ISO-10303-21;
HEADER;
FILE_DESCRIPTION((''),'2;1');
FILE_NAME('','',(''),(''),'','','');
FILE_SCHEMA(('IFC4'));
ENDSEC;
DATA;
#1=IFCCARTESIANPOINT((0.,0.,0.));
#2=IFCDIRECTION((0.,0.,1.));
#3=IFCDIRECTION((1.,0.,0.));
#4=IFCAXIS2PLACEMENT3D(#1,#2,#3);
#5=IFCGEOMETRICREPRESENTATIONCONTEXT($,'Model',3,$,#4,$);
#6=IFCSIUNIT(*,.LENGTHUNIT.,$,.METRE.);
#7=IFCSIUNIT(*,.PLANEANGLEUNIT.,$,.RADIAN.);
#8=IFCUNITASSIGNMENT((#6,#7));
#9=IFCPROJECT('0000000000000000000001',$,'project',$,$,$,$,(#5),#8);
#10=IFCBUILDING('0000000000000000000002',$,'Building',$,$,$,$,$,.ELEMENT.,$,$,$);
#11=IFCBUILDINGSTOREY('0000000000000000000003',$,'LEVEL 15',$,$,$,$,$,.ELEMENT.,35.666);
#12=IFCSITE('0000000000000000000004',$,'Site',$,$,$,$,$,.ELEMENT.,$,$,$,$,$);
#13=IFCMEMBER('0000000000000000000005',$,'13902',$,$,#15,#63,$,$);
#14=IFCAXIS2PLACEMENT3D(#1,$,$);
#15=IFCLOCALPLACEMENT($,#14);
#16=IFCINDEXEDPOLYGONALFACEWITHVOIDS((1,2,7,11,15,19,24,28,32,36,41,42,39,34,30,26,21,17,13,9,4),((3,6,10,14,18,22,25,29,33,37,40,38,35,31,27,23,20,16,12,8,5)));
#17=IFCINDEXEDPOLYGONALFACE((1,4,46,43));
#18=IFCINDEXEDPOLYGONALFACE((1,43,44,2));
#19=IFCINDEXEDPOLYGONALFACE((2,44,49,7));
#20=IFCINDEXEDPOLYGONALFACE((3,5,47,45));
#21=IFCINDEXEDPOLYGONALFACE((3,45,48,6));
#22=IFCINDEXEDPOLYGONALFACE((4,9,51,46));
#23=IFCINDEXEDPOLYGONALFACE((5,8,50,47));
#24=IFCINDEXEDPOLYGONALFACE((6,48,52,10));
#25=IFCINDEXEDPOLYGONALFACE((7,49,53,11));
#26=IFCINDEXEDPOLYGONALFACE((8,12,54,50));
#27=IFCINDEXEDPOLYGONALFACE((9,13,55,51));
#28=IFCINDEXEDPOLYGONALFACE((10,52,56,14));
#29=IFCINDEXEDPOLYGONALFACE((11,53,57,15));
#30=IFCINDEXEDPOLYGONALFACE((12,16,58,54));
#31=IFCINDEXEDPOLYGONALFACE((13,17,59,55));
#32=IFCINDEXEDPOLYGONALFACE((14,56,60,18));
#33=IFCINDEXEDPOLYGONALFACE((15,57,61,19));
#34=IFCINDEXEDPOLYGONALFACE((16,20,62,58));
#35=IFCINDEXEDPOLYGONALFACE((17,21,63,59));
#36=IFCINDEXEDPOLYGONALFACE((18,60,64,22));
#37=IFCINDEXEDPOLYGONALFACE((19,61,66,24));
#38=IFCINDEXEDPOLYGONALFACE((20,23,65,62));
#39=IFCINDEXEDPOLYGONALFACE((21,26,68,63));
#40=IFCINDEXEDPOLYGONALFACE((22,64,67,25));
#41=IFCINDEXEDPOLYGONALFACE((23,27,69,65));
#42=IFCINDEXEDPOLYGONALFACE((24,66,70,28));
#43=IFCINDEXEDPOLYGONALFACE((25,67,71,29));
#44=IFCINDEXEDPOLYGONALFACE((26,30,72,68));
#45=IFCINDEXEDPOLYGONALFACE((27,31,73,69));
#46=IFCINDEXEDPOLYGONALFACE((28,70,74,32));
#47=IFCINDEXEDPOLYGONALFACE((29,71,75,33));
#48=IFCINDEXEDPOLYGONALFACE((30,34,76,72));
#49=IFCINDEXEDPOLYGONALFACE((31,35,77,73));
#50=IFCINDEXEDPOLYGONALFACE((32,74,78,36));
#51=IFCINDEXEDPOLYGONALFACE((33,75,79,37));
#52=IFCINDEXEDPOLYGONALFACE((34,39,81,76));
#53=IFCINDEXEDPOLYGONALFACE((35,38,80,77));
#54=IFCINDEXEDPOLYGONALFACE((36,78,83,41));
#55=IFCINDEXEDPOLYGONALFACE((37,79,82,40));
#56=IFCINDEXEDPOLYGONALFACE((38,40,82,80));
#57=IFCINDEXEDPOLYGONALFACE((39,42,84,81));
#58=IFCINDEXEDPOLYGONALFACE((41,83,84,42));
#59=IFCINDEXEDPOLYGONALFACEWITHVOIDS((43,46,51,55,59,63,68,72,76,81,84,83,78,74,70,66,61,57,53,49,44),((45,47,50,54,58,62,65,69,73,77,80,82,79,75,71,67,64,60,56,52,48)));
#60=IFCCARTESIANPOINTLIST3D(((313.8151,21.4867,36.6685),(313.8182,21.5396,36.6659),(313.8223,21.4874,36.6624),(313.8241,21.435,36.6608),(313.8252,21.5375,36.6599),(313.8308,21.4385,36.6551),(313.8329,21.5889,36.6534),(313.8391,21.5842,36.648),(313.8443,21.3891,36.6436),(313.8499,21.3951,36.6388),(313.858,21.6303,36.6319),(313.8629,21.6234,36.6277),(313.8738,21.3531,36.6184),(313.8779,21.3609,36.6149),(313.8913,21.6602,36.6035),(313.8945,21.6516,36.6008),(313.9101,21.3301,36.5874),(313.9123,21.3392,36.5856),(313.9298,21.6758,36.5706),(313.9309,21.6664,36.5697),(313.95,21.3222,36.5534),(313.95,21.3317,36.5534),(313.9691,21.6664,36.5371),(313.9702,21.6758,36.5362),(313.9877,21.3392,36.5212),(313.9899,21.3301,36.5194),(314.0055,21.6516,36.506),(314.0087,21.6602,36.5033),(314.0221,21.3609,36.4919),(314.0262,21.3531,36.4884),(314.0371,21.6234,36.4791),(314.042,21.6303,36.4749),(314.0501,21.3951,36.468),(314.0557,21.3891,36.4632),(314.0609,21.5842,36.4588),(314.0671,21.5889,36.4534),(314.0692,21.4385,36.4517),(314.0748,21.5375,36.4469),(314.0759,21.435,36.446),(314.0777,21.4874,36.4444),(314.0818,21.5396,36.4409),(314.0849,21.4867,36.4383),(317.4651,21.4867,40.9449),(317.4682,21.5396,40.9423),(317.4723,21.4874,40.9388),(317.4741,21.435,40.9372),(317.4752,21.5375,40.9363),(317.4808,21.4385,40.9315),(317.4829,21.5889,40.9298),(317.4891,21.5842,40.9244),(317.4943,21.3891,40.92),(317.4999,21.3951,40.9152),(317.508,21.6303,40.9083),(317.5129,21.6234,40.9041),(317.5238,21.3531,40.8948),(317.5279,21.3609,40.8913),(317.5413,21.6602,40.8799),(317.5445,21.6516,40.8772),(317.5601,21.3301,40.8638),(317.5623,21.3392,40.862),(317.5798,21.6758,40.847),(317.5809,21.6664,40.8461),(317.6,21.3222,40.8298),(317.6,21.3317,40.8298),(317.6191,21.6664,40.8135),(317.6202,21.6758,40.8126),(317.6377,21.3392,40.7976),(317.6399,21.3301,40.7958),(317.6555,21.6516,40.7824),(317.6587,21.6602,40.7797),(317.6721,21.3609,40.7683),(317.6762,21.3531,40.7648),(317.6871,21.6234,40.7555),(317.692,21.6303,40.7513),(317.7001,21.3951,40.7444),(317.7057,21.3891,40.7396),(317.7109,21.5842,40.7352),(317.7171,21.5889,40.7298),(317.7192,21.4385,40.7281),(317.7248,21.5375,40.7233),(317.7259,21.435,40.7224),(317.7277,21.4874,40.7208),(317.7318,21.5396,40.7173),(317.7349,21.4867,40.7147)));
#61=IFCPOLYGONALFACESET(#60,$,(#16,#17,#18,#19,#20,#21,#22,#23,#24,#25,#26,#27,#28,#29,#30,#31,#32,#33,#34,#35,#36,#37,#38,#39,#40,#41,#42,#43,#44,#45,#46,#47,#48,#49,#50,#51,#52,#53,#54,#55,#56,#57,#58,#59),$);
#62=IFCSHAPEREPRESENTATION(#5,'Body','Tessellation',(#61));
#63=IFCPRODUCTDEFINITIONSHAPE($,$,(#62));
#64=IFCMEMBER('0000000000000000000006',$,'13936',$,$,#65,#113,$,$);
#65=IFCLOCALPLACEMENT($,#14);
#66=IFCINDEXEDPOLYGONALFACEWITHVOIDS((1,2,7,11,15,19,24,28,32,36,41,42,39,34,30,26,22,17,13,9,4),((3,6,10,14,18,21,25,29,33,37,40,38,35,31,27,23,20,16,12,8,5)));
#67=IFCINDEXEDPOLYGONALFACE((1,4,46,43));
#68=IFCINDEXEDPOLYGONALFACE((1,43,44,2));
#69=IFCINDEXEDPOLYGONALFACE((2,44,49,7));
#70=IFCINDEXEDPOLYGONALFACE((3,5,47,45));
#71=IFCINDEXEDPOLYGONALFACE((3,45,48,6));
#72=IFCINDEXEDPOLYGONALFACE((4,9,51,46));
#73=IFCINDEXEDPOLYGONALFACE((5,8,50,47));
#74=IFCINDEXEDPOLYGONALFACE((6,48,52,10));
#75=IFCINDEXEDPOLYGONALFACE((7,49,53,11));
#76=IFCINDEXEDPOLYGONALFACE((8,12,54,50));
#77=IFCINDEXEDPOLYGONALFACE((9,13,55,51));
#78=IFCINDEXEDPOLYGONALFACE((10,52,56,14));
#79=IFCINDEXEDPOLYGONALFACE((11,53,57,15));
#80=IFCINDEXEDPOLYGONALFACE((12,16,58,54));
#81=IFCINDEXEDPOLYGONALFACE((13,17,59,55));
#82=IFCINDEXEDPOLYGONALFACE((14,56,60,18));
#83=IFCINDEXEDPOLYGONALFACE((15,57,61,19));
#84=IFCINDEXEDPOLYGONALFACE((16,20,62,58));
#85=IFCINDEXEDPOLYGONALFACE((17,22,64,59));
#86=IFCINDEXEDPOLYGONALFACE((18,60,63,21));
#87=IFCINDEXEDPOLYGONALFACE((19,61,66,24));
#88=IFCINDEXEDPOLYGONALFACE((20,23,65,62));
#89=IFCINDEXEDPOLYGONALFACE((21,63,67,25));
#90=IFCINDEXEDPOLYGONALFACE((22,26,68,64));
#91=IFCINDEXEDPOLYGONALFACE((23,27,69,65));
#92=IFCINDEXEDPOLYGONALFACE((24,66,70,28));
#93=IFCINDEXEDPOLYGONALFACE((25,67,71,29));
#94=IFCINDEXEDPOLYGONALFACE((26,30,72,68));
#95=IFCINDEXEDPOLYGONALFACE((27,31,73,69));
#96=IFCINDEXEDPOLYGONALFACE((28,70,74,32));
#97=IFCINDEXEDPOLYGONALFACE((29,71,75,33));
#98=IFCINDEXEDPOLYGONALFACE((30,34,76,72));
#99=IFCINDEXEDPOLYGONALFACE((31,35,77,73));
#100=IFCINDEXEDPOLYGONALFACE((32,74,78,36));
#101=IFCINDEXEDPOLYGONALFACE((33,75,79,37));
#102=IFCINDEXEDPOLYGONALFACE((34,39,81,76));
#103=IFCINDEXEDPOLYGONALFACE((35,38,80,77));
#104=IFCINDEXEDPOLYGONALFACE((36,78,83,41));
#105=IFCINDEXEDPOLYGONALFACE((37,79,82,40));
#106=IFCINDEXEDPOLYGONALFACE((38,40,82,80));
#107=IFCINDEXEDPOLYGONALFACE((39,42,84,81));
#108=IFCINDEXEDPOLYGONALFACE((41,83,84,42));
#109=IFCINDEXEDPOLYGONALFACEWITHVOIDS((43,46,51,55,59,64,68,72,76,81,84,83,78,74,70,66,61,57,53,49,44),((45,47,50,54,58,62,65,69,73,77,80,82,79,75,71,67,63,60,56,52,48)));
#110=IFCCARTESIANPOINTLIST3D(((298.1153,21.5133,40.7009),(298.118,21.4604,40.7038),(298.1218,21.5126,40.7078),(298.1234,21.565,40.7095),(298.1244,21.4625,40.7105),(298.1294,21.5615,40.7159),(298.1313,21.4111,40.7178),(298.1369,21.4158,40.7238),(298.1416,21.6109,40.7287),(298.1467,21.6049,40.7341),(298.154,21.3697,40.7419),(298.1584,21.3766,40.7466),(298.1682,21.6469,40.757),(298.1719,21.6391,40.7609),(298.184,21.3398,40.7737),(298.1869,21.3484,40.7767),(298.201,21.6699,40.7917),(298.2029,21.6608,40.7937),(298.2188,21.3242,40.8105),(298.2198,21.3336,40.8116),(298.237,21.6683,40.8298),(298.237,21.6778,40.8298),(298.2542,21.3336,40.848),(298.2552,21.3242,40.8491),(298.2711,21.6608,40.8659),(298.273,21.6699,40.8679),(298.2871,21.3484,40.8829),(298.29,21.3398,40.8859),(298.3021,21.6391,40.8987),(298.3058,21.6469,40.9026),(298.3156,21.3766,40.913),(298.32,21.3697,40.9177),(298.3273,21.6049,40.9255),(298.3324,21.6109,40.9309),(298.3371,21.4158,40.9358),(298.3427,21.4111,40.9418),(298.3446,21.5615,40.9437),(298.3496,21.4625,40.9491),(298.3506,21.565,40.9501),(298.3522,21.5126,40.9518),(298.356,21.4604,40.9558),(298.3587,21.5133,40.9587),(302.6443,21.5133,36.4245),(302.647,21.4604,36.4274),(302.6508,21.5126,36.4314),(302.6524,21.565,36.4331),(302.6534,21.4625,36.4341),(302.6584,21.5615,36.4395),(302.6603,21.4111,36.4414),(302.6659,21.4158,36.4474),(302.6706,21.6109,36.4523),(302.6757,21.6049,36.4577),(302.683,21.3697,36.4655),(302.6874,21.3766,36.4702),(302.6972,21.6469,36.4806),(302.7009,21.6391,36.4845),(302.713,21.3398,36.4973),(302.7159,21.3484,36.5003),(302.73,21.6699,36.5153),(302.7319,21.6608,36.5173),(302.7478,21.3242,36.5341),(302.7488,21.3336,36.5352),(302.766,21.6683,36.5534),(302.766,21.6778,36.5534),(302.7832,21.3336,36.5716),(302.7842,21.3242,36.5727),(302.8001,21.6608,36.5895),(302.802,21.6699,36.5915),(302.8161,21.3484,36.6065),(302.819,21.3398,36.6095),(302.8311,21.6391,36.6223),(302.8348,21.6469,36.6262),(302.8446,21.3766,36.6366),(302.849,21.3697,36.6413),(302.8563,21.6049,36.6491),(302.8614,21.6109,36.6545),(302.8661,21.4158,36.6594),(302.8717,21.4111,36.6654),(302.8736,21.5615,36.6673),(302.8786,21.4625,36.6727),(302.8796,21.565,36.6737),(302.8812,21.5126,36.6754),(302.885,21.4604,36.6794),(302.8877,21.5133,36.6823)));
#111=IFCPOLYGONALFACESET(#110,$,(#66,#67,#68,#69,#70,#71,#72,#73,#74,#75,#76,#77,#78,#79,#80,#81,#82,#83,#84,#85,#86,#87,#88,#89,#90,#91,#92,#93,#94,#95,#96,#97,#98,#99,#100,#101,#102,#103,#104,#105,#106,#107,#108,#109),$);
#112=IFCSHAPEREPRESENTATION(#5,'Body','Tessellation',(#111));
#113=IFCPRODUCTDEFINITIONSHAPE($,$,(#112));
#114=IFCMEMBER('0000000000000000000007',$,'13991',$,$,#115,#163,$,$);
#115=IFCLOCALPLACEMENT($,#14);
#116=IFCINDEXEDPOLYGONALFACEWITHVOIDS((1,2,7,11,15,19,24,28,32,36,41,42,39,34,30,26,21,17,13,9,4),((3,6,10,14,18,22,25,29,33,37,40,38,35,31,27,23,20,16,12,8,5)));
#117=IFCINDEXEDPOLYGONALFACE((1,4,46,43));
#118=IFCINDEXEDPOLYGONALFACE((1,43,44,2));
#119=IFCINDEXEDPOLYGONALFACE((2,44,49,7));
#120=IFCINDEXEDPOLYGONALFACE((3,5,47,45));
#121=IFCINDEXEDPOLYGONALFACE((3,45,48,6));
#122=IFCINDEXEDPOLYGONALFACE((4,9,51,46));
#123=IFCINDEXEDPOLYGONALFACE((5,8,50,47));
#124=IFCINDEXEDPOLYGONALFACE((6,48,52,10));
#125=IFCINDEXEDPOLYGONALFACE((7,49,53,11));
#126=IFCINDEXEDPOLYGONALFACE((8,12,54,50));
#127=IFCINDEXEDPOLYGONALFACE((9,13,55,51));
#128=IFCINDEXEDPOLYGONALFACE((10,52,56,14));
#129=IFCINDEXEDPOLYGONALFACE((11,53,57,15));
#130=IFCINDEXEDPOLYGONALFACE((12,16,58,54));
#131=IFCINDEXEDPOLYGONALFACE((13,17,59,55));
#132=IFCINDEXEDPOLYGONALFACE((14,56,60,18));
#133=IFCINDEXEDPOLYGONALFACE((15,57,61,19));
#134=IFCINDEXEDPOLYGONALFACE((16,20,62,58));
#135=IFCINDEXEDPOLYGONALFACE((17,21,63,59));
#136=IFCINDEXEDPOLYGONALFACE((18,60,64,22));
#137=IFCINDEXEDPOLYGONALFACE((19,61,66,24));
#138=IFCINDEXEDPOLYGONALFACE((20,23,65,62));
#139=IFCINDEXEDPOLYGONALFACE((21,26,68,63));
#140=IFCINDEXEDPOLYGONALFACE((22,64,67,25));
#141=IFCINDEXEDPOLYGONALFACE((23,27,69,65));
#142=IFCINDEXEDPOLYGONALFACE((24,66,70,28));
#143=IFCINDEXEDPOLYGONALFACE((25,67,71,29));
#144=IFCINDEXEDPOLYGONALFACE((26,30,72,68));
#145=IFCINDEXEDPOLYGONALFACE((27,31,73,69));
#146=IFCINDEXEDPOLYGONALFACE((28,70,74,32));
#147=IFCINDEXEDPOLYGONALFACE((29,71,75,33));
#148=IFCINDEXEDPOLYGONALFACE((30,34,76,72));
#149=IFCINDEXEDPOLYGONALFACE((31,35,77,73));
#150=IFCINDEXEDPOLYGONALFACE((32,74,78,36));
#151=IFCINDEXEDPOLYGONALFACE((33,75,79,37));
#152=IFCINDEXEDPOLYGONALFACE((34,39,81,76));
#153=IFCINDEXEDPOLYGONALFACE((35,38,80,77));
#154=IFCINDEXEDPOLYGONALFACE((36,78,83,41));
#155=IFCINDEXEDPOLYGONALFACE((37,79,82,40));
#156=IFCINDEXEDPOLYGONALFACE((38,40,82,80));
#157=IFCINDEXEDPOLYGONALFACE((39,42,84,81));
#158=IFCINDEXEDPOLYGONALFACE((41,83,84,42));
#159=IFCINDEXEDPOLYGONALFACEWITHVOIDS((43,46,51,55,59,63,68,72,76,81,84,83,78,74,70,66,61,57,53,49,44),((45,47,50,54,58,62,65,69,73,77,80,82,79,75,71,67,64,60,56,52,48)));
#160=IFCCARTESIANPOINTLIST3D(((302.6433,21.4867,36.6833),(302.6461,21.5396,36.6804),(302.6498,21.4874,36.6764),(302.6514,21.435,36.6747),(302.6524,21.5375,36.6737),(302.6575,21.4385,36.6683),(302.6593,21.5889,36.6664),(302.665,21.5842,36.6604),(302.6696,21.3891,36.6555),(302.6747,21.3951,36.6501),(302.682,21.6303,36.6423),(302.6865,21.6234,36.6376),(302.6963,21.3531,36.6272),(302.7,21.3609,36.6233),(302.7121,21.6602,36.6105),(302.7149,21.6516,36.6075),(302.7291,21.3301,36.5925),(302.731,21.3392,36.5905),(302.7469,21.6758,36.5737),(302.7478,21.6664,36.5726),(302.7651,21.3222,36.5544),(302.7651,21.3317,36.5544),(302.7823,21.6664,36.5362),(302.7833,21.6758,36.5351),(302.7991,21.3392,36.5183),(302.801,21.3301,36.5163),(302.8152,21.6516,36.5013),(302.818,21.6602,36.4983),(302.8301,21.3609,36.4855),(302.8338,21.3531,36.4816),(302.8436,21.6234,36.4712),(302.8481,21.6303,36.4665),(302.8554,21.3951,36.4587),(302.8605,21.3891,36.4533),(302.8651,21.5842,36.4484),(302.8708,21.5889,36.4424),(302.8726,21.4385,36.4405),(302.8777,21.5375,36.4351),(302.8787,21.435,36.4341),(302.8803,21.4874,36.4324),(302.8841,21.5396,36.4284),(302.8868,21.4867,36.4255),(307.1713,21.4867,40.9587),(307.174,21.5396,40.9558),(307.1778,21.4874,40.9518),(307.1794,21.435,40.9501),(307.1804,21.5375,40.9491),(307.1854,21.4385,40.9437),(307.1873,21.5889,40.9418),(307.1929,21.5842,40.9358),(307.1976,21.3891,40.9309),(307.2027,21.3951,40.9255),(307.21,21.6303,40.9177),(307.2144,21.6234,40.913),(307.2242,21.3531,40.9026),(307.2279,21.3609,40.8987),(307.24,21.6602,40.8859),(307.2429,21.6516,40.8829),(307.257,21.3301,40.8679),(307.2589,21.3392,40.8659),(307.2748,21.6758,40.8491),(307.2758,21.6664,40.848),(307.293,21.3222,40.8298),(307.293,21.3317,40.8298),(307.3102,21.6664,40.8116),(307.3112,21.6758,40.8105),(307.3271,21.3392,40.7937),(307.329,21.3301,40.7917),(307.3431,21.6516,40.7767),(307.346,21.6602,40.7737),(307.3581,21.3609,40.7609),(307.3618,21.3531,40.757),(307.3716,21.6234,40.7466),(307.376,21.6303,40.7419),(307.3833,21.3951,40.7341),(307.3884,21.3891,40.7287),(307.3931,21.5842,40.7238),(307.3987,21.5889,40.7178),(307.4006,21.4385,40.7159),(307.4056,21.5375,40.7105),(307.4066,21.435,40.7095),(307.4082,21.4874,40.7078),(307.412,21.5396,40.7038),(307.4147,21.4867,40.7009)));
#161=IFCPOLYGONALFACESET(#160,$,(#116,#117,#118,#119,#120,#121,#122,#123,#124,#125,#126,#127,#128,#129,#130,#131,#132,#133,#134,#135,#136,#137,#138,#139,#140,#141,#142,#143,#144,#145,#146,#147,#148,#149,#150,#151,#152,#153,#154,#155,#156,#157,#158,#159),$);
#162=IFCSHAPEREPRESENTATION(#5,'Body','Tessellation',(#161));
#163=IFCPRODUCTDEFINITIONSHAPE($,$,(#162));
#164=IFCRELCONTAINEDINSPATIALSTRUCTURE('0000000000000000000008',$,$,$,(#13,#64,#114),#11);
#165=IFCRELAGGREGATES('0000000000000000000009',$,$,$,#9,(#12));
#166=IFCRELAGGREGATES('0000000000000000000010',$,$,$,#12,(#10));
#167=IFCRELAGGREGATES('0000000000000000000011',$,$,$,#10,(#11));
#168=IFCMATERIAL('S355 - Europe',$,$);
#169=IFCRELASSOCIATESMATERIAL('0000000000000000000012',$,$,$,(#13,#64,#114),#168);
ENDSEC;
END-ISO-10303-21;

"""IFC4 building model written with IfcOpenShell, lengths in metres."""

from ifc_helpers import new_model, si_unit, frame, origin_with_axes, origin_2d_with_axis, place, context, project, spatial, hollow_circle, extrude, material, material_profile, profile_set, profile_usage, element, save


model = new_model("IFC4")

# Units and contexts
model_context = context("Model", 3, world=origin_with_axes())
ifc_project = project(units=[si_unit("LENGTHUNIT", "METRE"), si_unit("PLANEANGLEUNIT", "RADIAN")], contexts=[model_context])

# Site, building, storey
site = spatial("IfcSite", under=ifc_project, Name="Site", CompositionType="ELEMENT")
building = spatial("IfcBuilding", under=site, Name="Building", CompositionType="ELEMENT")
storey = spatial("IfcBuildingStorey", under=building, Name="LEVEL 15", CompositionType="ELEMENT", Elevation=35.666)

# Shared definitions
ifc_material = material(Name="S355 - Europe")

# Members
ifc_material_profile_1 = material_profile(ifc_material, hollow_circle(Radius=0.1778, WallThickness=0.0095, at=origin_2d_with_axis()))
ifc_profile_set_1 = profile_set([ifc_material_profile_1])
ifc_profile_usage_1 = profile_usage(ifc_profile_set_1, cardinal=10)
member_1_placement = place(None, frame((317.6, 21.5, 40.8298), z_axis=(-0.649202, 0.0, -0.760616), x_axis=(0.0, -1.0, 0.0)))
element("IfcMember", 1, at=member_1_placement, inside=storey, material=ifc_profile_usage_1, Name="13902", context=model_context, shape_type="SweptSolid", body=[
    extrude(hollow_circle(Radius=0.1778, WallThickness=0.0095, at=origin_2d_with_axis()), origin_with_axes(), (0.0, 0.0, 1.0), 5.6223),
])
ifc_material_profile_2 = material_profile(ifc_material, hollow_circle(Radius=0.1778, WallThickness=0.0095, at=origin_2d_with_axis()))
ifc_profile_set_2 = profile_set([ifc_material_profile_2])
ifc_profile_usage_2 = profile_usage(ifc_profile_set_2, cardinal=10)
member_2_placement = place(None, frame((298.237, 21.5, 40.8298), z_axis=(0.727092, 0.0, -0.68654), x_axis=(0.0, 1.0, 0.0)))
element("IfcMember", 2, at=member_2_placement, inside=storey, material=ifc_profile_usage_2, Name="13936", context=model_context, shape_type="SweptSolid", body=[
    extrude(hollow_circle(Radius=0.1778, WallThickness=0.0095, at=origin_2d_with_axis()), origin_with_axes(), (0.0, 0.0, 1.0), 6.2289),
])
ifc_material_profile_3 = material_profile(ifc_material, hollow_circle(Radius=0.1778, WallThickness=0.0095, at=origin_2d_with_axis()))
ifc_profile_set_3 = profile_set([ifc_material_profile_3])
ifc_profile_usage_3 = profile_usage(ifc_profile_set_3, cardinal=10)
member_3_placement = place(None, frame((307.293, 21.5, 40.8298), z_axis=(-0.727092, 0.0, -0.68654), x_axis=(0.0, -1.0, 0.0)))
element("IfcMember", 3, at=member_3_placement, inside=storey, material=ifc_profile_usage_3, Name="13991", context=model_context, shape_type="SweptSolid", body=[
    extrude(hollow_circle(Radius=0.1778, WallThickness=0.0095, at=origin_2d_with_axis()), origin_with_axes(), (0.0, 0.0, 1.0), 6.2275),
])

save(model, "model.ifc")
